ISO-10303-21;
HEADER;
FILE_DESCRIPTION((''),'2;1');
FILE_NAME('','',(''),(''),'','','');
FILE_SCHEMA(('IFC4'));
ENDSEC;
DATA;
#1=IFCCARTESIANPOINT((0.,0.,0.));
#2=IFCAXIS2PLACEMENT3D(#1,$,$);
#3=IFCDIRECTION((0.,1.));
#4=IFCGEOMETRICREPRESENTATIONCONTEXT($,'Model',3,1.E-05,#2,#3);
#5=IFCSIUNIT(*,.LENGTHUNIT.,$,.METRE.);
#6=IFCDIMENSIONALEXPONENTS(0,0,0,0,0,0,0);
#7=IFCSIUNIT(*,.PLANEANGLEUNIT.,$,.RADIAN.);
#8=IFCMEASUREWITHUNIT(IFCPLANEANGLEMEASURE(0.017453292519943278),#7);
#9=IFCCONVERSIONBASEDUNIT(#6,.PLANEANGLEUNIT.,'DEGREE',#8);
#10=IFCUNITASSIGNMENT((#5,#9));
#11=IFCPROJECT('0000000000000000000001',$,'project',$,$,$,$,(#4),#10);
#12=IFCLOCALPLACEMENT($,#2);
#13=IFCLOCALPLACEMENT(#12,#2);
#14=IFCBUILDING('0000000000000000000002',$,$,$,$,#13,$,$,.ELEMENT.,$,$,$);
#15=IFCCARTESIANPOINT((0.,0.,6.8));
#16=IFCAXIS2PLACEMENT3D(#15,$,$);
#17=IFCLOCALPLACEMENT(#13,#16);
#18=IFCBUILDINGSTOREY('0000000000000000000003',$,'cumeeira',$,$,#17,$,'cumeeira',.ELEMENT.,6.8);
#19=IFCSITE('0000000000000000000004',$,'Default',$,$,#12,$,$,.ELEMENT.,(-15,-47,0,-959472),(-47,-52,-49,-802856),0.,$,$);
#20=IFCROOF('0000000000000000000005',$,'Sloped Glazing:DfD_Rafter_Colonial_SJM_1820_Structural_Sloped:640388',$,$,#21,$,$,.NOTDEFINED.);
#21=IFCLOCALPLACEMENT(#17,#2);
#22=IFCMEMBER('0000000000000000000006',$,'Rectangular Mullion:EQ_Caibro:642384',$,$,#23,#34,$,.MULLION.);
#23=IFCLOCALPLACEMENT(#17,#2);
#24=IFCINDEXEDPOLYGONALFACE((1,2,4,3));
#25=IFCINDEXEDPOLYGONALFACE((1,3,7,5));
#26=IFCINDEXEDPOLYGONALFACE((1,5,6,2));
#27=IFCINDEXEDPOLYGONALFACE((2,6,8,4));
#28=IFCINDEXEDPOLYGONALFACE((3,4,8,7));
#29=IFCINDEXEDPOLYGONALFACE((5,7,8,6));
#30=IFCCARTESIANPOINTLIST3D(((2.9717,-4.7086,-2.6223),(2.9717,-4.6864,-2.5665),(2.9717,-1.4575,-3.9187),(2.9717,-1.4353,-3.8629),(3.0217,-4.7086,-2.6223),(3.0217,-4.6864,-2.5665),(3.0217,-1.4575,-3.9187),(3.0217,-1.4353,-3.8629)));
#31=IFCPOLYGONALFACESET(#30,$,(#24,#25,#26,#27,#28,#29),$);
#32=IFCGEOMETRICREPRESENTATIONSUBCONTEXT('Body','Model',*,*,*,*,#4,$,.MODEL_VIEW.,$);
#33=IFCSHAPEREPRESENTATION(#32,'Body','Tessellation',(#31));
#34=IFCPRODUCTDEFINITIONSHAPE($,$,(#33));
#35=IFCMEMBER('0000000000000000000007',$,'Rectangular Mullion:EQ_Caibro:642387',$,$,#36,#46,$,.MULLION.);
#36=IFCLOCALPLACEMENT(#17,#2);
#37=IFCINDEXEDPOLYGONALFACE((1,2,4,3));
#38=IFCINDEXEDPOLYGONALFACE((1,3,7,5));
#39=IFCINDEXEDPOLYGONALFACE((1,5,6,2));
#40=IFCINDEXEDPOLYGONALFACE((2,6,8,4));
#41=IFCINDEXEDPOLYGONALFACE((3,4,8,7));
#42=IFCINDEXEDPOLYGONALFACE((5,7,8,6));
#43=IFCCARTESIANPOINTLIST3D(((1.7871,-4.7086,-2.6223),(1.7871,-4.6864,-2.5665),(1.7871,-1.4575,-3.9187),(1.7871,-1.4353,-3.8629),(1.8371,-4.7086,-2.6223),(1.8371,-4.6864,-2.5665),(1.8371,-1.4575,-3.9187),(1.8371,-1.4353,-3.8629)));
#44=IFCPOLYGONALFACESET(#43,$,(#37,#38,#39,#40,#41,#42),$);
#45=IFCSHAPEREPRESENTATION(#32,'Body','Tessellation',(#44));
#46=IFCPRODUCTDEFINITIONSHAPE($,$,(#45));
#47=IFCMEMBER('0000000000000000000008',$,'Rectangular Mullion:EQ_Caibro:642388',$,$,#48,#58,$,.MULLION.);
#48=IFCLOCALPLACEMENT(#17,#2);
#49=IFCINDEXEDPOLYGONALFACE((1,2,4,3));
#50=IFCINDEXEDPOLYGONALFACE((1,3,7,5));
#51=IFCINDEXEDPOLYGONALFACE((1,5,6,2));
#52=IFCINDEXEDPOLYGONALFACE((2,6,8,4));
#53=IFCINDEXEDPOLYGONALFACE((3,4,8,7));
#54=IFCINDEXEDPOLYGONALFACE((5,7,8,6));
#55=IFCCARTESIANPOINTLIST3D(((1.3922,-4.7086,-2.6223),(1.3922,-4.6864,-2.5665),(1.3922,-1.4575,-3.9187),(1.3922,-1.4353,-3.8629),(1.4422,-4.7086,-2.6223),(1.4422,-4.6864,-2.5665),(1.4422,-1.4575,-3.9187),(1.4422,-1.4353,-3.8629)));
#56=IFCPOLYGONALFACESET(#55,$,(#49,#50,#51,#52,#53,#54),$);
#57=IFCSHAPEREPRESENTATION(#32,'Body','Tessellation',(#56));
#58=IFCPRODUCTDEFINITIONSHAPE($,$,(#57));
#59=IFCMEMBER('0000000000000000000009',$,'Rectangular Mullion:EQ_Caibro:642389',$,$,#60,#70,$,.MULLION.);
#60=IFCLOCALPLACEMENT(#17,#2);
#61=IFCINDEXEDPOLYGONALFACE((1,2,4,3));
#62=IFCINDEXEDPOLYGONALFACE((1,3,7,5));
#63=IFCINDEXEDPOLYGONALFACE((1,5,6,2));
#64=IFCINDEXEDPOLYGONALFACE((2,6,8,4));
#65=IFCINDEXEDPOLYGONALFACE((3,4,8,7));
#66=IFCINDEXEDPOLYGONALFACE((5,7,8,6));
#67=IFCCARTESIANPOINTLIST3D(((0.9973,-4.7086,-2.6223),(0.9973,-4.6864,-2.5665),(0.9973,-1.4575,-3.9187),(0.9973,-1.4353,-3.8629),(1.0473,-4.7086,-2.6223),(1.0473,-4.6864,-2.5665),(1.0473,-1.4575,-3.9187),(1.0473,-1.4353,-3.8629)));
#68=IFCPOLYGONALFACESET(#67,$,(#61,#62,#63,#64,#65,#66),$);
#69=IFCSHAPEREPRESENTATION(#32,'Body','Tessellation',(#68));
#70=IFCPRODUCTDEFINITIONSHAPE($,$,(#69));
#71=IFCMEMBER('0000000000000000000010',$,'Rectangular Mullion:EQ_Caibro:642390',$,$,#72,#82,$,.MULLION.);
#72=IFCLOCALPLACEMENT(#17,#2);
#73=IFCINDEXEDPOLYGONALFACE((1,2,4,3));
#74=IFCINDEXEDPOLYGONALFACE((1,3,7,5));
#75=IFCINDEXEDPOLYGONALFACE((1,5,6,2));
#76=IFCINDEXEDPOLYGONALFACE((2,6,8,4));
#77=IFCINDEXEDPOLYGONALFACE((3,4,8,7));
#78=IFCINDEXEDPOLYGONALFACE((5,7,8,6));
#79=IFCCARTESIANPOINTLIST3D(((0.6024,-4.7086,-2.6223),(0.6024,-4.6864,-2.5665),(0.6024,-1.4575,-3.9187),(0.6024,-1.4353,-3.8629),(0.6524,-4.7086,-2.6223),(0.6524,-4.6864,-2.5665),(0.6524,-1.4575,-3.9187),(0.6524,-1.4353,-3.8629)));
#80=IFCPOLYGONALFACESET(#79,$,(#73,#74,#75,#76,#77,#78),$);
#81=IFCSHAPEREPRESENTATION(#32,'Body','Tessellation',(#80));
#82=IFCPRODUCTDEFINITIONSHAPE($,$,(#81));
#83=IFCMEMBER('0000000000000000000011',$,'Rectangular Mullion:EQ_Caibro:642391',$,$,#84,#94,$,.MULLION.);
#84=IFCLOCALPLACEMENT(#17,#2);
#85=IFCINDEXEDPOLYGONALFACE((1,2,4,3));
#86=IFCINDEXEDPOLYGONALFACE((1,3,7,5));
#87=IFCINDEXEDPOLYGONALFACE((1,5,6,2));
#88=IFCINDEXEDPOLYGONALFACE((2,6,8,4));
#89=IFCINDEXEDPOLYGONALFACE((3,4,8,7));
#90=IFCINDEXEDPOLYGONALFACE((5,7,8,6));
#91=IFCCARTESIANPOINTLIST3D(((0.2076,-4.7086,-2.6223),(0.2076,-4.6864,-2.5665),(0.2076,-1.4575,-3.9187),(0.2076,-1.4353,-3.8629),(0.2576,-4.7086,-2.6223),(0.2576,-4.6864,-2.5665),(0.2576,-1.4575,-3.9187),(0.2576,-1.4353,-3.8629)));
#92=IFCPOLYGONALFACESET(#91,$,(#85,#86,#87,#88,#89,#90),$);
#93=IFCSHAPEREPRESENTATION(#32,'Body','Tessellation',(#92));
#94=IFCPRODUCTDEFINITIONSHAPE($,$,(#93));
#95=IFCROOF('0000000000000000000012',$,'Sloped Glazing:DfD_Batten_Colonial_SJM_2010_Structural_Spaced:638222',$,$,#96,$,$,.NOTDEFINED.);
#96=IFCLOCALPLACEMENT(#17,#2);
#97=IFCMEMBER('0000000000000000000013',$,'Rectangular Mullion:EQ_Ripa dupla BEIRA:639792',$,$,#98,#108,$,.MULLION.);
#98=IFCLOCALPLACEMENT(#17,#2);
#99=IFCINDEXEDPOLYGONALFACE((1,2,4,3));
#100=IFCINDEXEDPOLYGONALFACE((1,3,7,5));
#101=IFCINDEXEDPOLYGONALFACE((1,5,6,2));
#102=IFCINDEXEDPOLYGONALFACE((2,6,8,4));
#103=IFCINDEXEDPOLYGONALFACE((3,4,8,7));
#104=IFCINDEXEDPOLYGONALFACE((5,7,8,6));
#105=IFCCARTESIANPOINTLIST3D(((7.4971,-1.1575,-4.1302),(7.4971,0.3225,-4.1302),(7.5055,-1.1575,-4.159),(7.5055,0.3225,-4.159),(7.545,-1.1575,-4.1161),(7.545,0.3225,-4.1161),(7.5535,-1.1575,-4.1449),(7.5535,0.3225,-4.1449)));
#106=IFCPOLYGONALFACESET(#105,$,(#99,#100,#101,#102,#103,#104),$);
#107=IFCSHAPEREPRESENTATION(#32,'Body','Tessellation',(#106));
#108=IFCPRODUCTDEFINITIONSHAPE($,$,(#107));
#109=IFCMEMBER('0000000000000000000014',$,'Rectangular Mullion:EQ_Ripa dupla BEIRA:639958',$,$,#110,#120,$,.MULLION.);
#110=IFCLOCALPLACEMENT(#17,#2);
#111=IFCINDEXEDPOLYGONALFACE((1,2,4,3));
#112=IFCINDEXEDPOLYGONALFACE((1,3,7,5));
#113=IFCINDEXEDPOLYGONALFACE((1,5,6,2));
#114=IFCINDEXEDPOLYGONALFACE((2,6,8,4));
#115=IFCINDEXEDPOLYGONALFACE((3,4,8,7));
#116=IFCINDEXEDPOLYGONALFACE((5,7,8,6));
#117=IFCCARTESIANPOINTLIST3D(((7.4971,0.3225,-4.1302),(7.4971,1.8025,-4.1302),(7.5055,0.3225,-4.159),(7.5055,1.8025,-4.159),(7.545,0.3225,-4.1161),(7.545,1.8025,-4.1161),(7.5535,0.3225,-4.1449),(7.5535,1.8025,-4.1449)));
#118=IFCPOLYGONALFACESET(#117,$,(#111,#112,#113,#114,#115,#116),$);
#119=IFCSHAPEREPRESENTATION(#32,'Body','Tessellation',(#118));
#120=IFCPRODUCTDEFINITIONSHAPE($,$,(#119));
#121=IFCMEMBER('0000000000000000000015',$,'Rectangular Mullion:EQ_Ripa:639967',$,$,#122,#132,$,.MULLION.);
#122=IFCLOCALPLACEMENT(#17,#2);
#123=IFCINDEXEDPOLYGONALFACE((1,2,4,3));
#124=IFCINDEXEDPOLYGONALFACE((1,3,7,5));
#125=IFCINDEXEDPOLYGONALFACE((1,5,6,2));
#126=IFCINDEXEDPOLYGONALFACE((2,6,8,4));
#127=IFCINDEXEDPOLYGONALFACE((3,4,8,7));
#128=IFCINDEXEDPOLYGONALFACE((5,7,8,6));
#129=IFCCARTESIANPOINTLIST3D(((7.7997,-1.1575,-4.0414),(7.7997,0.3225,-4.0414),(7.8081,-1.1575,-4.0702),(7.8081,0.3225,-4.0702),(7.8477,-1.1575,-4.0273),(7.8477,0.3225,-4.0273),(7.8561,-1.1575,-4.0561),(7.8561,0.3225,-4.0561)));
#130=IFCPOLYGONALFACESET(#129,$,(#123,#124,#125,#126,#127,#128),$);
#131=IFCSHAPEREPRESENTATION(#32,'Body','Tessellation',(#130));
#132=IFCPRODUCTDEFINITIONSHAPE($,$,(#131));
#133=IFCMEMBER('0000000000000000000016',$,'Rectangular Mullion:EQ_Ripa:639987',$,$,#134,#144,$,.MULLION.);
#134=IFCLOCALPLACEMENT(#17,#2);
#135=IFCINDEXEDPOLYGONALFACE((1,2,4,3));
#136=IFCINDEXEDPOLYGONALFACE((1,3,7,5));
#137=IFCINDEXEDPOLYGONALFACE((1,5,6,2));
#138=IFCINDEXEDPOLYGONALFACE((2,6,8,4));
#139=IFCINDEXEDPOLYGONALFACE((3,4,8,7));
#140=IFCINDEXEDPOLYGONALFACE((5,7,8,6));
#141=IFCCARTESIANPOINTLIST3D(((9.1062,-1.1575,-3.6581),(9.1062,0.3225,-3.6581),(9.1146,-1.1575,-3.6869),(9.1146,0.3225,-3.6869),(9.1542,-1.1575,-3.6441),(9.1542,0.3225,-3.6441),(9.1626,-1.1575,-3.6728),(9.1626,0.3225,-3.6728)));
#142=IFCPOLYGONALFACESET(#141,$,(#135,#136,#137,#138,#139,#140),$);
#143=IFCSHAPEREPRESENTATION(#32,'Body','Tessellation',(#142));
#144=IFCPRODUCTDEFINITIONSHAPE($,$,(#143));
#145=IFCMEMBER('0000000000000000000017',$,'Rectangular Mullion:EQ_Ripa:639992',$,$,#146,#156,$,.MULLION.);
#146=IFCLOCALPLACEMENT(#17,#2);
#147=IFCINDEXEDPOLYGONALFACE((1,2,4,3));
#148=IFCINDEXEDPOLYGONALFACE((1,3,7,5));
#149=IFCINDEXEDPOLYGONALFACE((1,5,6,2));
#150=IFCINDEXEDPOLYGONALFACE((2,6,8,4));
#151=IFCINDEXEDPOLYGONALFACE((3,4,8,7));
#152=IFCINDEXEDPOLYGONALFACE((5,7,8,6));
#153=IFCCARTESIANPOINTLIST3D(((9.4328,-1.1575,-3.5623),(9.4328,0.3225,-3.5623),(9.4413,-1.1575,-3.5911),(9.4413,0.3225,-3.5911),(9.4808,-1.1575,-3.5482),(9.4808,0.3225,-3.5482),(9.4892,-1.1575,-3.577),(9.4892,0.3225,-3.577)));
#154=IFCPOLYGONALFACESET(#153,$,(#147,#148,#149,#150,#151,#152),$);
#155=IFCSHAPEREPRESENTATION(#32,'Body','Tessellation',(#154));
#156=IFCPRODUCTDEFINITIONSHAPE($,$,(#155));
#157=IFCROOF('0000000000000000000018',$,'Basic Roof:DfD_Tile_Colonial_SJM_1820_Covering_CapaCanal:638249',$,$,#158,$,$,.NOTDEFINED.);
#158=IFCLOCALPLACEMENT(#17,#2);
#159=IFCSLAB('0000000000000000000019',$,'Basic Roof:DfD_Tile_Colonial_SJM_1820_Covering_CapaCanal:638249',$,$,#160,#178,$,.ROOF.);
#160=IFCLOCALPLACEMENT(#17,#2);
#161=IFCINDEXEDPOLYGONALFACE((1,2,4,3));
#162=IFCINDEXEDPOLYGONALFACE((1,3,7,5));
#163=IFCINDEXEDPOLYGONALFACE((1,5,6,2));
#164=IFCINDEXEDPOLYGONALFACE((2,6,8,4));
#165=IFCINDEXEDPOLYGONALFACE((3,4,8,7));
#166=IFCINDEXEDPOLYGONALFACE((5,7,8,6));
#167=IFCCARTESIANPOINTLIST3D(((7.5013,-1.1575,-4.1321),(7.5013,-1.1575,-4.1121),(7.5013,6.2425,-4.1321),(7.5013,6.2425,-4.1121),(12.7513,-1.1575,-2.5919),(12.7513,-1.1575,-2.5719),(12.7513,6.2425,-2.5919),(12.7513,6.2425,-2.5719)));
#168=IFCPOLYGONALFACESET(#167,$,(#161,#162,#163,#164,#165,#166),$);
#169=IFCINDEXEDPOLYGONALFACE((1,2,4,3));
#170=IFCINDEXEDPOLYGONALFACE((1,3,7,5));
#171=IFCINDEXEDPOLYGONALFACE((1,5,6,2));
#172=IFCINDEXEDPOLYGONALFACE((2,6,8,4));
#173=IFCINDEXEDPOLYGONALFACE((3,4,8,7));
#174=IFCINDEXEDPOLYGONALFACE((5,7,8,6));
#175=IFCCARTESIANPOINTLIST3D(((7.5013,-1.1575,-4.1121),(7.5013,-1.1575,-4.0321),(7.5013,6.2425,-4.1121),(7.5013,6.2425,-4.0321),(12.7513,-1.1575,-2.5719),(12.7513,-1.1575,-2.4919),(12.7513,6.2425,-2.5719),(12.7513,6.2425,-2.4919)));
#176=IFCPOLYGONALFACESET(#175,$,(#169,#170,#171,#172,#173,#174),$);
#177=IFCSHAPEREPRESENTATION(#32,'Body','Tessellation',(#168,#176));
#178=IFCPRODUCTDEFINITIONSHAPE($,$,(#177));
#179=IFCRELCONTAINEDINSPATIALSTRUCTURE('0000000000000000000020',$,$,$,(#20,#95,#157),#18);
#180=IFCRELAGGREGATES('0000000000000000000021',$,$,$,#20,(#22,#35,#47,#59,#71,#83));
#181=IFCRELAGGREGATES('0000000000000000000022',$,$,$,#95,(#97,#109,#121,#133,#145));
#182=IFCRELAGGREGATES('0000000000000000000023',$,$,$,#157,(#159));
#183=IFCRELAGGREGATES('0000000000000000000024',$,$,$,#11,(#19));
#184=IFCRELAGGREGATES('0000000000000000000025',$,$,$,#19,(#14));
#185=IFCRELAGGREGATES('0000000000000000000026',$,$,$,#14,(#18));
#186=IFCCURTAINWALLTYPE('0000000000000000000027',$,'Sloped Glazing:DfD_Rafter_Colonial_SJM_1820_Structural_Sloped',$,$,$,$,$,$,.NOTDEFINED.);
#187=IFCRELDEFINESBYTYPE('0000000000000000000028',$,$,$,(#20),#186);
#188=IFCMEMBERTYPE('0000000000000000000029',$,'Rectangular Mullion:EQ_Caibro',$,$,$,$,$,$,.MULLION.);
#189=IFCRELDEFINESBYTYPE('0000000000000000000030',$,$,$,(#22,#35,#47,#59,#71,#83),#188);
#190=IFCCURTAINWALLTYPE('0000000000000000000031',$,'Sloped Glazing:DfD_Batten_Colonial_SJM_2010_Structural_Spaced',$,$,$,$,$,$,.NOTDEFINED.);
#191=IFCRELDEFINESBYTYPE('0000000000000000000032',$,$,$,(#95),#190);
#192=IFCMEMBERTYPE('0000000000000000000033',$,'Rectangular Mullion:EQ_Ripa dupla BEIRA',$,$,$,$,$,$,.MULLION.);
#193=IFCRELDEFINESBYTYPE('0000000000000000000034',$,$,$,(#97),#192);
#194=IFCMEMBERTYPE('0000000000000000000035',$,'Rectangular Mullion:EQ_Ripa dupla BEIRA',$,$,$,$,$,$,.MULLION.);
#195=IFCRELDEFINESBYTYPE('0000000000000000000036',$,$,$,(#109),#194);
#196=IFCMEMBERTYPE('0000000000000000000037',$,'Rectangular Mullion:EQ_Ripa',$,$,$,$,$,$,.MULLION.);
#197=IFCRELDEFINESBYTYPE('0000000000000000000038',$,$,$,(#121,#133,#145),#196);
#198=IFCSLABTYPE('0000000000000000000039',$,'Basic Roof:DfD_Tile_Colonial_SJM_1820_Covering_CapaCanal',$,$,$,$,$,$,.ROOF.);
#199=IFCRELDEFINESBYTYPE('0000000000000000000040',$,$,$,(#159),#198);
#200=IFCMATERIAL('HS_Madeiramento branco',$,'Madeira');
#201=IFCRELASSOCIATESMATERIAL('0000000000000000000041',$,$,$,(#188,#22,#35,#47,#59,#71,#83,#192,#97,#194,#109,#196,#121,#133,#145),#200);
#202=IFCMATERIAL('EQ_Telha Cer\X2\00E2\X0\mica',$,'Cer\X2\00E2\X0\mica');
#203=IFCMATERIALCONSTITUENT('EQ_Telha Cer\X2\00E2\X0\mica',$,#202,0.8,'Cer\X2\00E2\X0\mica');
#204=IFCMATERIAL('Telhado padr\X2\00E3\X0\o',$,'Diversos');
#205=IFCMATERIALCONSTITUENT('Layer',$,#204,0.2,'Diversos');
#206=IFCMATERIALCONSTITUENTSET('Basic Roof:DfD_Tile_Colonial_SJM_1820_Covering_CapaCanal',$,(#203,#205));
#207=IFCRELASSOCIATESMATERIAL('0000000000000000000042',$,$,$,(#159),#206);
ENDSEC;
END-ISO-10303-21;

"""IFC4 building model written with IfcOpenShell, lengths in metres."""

from ifc_helpers import new_model, entity, si_unit, converted_unit, direction, frame, origin, place, context, subcontext, project, spatial, indexed_curve, outline, extrude, source, transform, mapped, material, constituent, constituent_set, type_object, type_shapes, element, aggregate, save


model = new_model("IFC4")

# Units and contexts
model_context = context("Model", 3, precision=1e-05, world=origin(), true_north=direction((0.0, 1.0)))
body_context = subcontext(model_context, "Body", "Model", "MODEL_VIEW")
ifc_project = project(units=[si_unit("LENGTHUNIT", "METRE"), converted_unit("PLANEANGLEUNIT", "DEGREE", entity("IfcPlaneAngleMeasure", 0.017453292519943278), si_unit("PLANEANGLEUNIT", "RADIAN"), dimensions=[0, 0, 0, 0, 0, 0, 0])], contexts=[model_context])

# Site, building, storey
site_placement = place(None, origin())
site = spatial("IfcSite", under=ifc_project, at=site_placement, Name="Default", CompositionType="ELEMENT", RefLatitude=(-15, -47, 0, -959472), RefLongitude=(-47, -52, -49, -802856), RefElevation=0.0)
building_placement = place(site_placement, origin())
building = spatial("IfcBuilding", under=site, at=building_placement, CompositionType="ELEMENT")
storey_placement = place(building_placement, frame((0.0, 0.0, 6.8)))
storey = spatial("IfcBuildingStorey", under=building, at=storey_placement, Name="cumeeira", LongName="cumeeira", CompositionType="ELEMENT", Elevation=6.8)

# Roofs, members
curtain_wall_type_1 = type_object("IfcCurtainWallType", Name="Sloped Glazing:DfD_Rafter_Colonial_SJM_1820_Structural_Sloped", PredefinedType="NOTDEFINED")
roof_1_placement = place(storey_placement, frame((0.0, 0.0, -6.8)))
roof_1 = element("IfcRoof", 1, at=roof_1_placement, inside=storey, type_object=curtain_wall_type_1, Name="Sloped Glazing:DfD_Rafter_Colonial_SJM_1820_Structural_Sloped:640388", PredefinedType="NOTDEFINED")
ifc_material_1 = material(Name="HS_Madeiramento branco", Category="Madeira")
member_type_1 = type_object("IfcMemberType", Name="Rectangular Mullion:EQ_Caibro", PredefinedType="MULLION", material=ifc_material_1)
shared_shape_1 = source(origin(), body_context, "Body", "SweptSolid", [
    extrude(outline(indexed_curve([(-0.025, -0.03), (0.025, -0.03), (0.025, 0.03), (-0.025, 0.03), (-0.025, -0.03)], self_intersect=False)), frame((0.0, -0.03, -3.5), z_axis=(0.0, 0.0, 1.0), x_axis=(-1.0, 0.0, 0.0)), (0.0, 0.0, 1.0), 3.5),
])
type_shapes(member_type_1, [shared_shape_1])
member_1_placement = place(roof_1_placement, frame((2.9967, -4.7086, 4.1777), z_axis=(0.0, -0.928874, 0.370395), x_axis=(-1.0, 0.0, 0.0)))
member_1 = element("IfcMember", 2, at=member_1_placement, type_object=member_type_1, material=ifc_material_1, Name="Rectangular Mullion:EQ_Caibro:642384", PredefinedType="MULLION", context=body_context, shape_type="MappedRepresentation", body=[
    mapped(shared_shape_1, transform((0.0, 0.0, 0.0), scale=1.0)),
])
member_2_placement = place(roof_1_placement, frame((1.8121, -4.7086, 4.1777), z_axis=(0.0, -0.928874, 0.370395), x_axis=(-1.0, 0.0, 0.0)))
member_2 = element("IfcMember", 3, at=member_2_placement, type_object=member_type_1, material=ifc_material_1, Name="Rectangular Mullion:EQ_Caibro:642387", PredefinedType="MULLION", context=body_context, shape_type="MappedRepresentation", body=[
    mapped(shared_shape_1, transform((0.0, 0.0, 0.0), scale=1.0)),
])
member_3_placement = place(roof_1_placement, frame((1.4172, -4.7086, 4.1777), z_axis=(0.0, -0.928874, 0.370395), x_axis=(-1.0, 0.0, 0.0)))
member_3 = element("IfcMember", 4, at=member_3_placement, type_object=member_type_1, material=ifc_material_1, Name="Rectangular Mullion:EQ_Caibro:642388", PredefinedType="MULLION", context=body_context, shape_type="MappedRepresentation", body=[
    mapped(shared_shape_1, transform((0.0, 0.0, 0.0), scale=1.0)),
])
member_4_placement = place(roof_1_placement, frame((1.0223, -4.7086, 4.1777), z_axis=(0.0, -0.928874, 0.370395), x_axis=(-1.0, 0.0, 0.0)))
member_4 = element("IfcMember", 5, at=member_4_placement, type_object=member_type_1, material=ifc_material_1, Name="Rectangular Mullion:EQ_Caibro:642389", PredefinedType="MULLION", context=body_context, shape_type="MappedRepresentation", body=[
    mapped(shared_shape_1, transform((0.0, 0.0, 0.0), scale=1.0)),
])
member_5_placement = place(roof_1_placement, frame((0.6274, -4.7086, 4.1777), z_axis=(0.0, -0.928874, 0.370395), x_axis=(-1.0, 0.0, 0.0)))
member_5 = element("IfcMember", 6, at=member_5_placement, type_object=member_type_1, material=ifc_material_1, Name="Rectangular Mullion:EQ_Caibro:642390", PredefinedType="MULLION", context=body_context, shape_type="MappedRepresentation", body=[
    mapped(shared_shape_1, transform((0.0, 0.0, 0.0), scale=1.0)),
])
member_6_placement = place(roof_1_placement, frame((0.2326, -4.7086, 4.1777), z_axis=(0.0, -0.928874, 0.370395), x_axis=(-1.0, 0.0, 0.0)))
member_6 = element("IfcMember", 7, at=member_6_placement, type_object=member_type_1, material=ifc_material_1, Name="Rectangular Mullion:EQ_Caibro:642391", PredefinedType="MULLION", context=body_context, shape_type="MappedRepresentation", body=[
    mapped(shared_shape_1, transform((0.0, 0.0, 0.0), scale=1.0)),
])
aggregate(roof_1, [member_1, member_2, member_3, member_4, member_5, member_6])
curtain_wall_type_2 = type_object("IfcCurtainWallType", Name="Sloped Glazing:DfD_Batten_Colonial_SJM_2010_Structural_Spaced", PredefinedType="NOTDEFINED")
roof_2_placement = place(storey_placement, frame((0.0, 0.0, -6.8)))
roof_2 = element("IfcRoof", 8, at=roof_2_placement, inside=storey, type_object=curtain_wall_type_2, Name="Sloped Glazing:DfD_Batten_Colonial_SJM_2010_Structural_Spaced:638222", PredefinedType="NOTDEFINED")
member_type_2 = type_object("IfcMemberType", Name="Rectangular Mullion:EQ_Ripa dupla BEIRA", PredefinedType="MULLION", material=ifc_material_1)
shared_shape_2 = source(origin(), body_context, "Body", "SweptSolid", [
    extrude(outline(indexed_curve([(-0.025, -0.015), (0.025, -0.015), (0.025, 0.015), (-0.025, 0.015), (-0.025, -0.015)], self_intersect=False)), frame((-0.025, 0.0, -1.48), z_axis=(0.0, 0.0, 1.0), x_axis=(-1.0, 0.0, 0.0)), (0.0, 0.0, 1.0), 1.48),
])
type_shapes(member_type_2, [shared_shape_2])
member_7_placement = place(roof_2_placement, frame((7.5013, -1.1575, 2.6554), z_axis=(0.0, -1.0, 0.0), x_axis=(-0.95956, 0.0, -0.281504)))
member_7 = element("IfcMember", 9, at=member_7_placement, type_object=member_type_2, material=ifc_material_1, Name="Rectangular Mullion:EQ_Ripa dupla BEIRA:639792", PredefinedType="MULLION", context=body_context, shape_type="MappedRepresentation", body=[
    mapped(shared_shape_2, transform((0.0, 0.0, 0.0), scale=1.0)),
])
member_type_3 = type_object("IfcMemberType", Name="Rectangular Mullion:EQ_Ripa dupla BEIRA", PredefinedType="MULLION", material=ifc_material_1)
shared_shape_3 = source(origin(), body_context, "Body", "SweptSolid", [
    extrude(outline(indexed_curve([(-0.025, -0.015), (0.025, -0.015), (0.025, 0.015), (-0.025, 0.015), (-0.025, -0.015)], self_intersect=False)), frame((-0.025, 0.0, -1.48), z_axis=(0.0, 0.0, 1.0), x_axis=(-1.0, 0.0, 0.0)), (0.0, 0.0, 1.0), 1.48),
])
type_shapes(member_type_3, [shared_shape_3])
member_8_placement = place(roof_2_placement, frame((7.5013, 0.3225, 2.6554), z_axis=(0.0, -1.0, 0.0), x_axis=(-0.95956, 0.0, -0.281504)))
member_8 = element("IfcMember", 10, at=member_8_placement, type_object=member_type_3, material=ifc_material_1, Name="Rectangular Mullion:EQ_Ripa dupla BEIRA:639958", PredefinedType="MULLION", context=body_context, shape_type="MappedRepresentation", body=[
    mapped(shared_shape_3, transform((0.0, 0.0, 0.0), scale=1.0)),
])
member_type_4 = type_object("IfcMemberType", Name="Rectangular Mullion:EQ_Ripa", PredefinedType="MULLION", material=ifc_material_1)
shared_shape_4 = source(origin(), body_context, "Body", "SweptSolid", [
    extrude(outline(indexed_curve([(-0.025, -0.015), (0.025, -0.015), (0.025, 0.015), (-0.025, 0.015), (-0.025, -0.015)], self_intersect=False)), frame((0.0, 0.0, -1.48), z_axis=(0.0, 0.0, 1.0), x_axis=(-1.0, 0.0, 0.0)), (0.0, 0.0, 1.0), 1.48),
])
type_shapes(member_type_4, [shared_shape_4])
member_9_placement = place(roof_2_placement, frame((7.8279, 0.3225, 2.7512), z_axis=(0.0, 1.0, 0.0), x_axis=(0.95956, 0.0, 0.281504)))
member_9 = element("IfcMember", 11, at=member_9_placement, type_object=member_type_4, material=ifc_material_1, Name="Rectangular Mullion:EQ_Ripa:639967", PredefinedType="MULLION", context=body_context, shape_type="MappedRepresentation", body=[
    mapped(shared_shape_4, transform((0.0, 0.0, 0.0), scale=1.0)),
])
member_10_placement = place(roof_2_placement, frame((9.1344, 0.3225, 3.1345), z_axis=(0.0, 1.0, 0.0), x_axis=(0.95956, 0.0, 0.281504)))
member_10 = element("IfcMember", 12, at=member_10_placement, type_object=member_type_4, material=ifc_material_1, Name="Rectangular Mullion:EQ_Ripa:639987", PredefinedType="MULLION", context=body_context, shape_type="MappedRepresentation", body=[
    mapped(shared_shape_4, transform((0.0, 0.0, 0.0), scale=1.0)),
])
member_11_placement = place(roof_2_placement, frame((9.461, 0.3225, 3.2303), z_axis=(0.0, 1.0, 0.0), x_axis=(0.95956, 0.0, 0.281504)))
member_11 = element("IfcMember", 13, at=member_11_placement, type_object=member_type_4, material=ifc_material_1, Name="Rectangular Mullion:EQ_Ripa:639992", PredefinedType="MULLION", context=body_context, shape_type="MappedRepresentation", body=[
    mapped(shared_shape_4, transform((0.0, 0.0, 0.0), scale=1.0)),
])
aggregate(roof_2, [member_7, member_8, member_9, member_10, member_11])

# Roof, slab
roof_3_placement = place(storey_placement, frame((7.5013, -1.1575, -4.1321)))
roof_3 = element("IfcRoof", 14, at=roof_3_placement, inside=storey, Name="Basic Roof:DfD_Tile_Colonial_SJM_1820_Covering_CapaCanal:638249", PredefinedType="NOTDEFINED")
ifc_material_2 = material(Name="EQ_Telha Cerâmica", Category="Cerâmica")
ifc_constituent_1 = constituent(ifc_material_2, Name="EQ_Telha Cerâmica", Category="Cerâmica", fraction=0.8)
ifc_material_3 = material(Name="Telhado padrão", Category="Diversos")
ifc_constituent_2 = constituent(ifc_material_3, Name="Layer", Category="Diversos", fraction=0.2)
ifc_constituent_set = constituent_set(constituents=[ifc_constituent_1, ifc_constituent_2], Name="Basic Roof:DfD_Tile_Colonial_SJM_1820_Covering_CapaCanal")
slab_type = type_object("IfcSlabType", Name="Basic Roof:DfD_Tile_Colonial_SJM_1820_Covering_CapaCanal", PredefinedType="ROOF")
slab_placement = place(roof_3_placement, origin())
slab = element("IfcSlab", 15, at=slab_placement, type_object=slab_type, material=ifc_constituent_set, Name="Basic Roof:DfD_Tile_Colonial_SJM_1820_Covering_CapaCanal:638249", PredefinedType="ROOF", context=body_context, shape_type="SweptSolid", body=[
    extrude(outline(indexed_curve([(-2.7356, 3.7), (-2.7356, -3.7), (2.7356, -3.7), (2.7356, 3.7), (-2.7356, 3.7)], self_intersect=False)), frame((2.625, 3.7, 0.7701), z_axis=(-0.281504, 0.0, 0.95956), x_axis=(0.95956, 0.0, 0.281504)), (0.281504, 0.0, 0.95956), 0.02),
    extrude(outline(indexed_curve([(-2.7356, 3.7), (-2.7356, -3.7), (2.7356, -3.7), (2.7356, 3.7), (-2.7356, 3.7)], self_intersect=False)), frame((2.625, 3.7, 0.7901), z_axis=(-0.281504, 0.0, 0.95956), x_axis=(0.95956, 0.0, 0.281504)), (0.281504, 0.0, 0.95956), 0.08),
])
aggregate(roof_3, [slab])

save(model, "model.ifc")
